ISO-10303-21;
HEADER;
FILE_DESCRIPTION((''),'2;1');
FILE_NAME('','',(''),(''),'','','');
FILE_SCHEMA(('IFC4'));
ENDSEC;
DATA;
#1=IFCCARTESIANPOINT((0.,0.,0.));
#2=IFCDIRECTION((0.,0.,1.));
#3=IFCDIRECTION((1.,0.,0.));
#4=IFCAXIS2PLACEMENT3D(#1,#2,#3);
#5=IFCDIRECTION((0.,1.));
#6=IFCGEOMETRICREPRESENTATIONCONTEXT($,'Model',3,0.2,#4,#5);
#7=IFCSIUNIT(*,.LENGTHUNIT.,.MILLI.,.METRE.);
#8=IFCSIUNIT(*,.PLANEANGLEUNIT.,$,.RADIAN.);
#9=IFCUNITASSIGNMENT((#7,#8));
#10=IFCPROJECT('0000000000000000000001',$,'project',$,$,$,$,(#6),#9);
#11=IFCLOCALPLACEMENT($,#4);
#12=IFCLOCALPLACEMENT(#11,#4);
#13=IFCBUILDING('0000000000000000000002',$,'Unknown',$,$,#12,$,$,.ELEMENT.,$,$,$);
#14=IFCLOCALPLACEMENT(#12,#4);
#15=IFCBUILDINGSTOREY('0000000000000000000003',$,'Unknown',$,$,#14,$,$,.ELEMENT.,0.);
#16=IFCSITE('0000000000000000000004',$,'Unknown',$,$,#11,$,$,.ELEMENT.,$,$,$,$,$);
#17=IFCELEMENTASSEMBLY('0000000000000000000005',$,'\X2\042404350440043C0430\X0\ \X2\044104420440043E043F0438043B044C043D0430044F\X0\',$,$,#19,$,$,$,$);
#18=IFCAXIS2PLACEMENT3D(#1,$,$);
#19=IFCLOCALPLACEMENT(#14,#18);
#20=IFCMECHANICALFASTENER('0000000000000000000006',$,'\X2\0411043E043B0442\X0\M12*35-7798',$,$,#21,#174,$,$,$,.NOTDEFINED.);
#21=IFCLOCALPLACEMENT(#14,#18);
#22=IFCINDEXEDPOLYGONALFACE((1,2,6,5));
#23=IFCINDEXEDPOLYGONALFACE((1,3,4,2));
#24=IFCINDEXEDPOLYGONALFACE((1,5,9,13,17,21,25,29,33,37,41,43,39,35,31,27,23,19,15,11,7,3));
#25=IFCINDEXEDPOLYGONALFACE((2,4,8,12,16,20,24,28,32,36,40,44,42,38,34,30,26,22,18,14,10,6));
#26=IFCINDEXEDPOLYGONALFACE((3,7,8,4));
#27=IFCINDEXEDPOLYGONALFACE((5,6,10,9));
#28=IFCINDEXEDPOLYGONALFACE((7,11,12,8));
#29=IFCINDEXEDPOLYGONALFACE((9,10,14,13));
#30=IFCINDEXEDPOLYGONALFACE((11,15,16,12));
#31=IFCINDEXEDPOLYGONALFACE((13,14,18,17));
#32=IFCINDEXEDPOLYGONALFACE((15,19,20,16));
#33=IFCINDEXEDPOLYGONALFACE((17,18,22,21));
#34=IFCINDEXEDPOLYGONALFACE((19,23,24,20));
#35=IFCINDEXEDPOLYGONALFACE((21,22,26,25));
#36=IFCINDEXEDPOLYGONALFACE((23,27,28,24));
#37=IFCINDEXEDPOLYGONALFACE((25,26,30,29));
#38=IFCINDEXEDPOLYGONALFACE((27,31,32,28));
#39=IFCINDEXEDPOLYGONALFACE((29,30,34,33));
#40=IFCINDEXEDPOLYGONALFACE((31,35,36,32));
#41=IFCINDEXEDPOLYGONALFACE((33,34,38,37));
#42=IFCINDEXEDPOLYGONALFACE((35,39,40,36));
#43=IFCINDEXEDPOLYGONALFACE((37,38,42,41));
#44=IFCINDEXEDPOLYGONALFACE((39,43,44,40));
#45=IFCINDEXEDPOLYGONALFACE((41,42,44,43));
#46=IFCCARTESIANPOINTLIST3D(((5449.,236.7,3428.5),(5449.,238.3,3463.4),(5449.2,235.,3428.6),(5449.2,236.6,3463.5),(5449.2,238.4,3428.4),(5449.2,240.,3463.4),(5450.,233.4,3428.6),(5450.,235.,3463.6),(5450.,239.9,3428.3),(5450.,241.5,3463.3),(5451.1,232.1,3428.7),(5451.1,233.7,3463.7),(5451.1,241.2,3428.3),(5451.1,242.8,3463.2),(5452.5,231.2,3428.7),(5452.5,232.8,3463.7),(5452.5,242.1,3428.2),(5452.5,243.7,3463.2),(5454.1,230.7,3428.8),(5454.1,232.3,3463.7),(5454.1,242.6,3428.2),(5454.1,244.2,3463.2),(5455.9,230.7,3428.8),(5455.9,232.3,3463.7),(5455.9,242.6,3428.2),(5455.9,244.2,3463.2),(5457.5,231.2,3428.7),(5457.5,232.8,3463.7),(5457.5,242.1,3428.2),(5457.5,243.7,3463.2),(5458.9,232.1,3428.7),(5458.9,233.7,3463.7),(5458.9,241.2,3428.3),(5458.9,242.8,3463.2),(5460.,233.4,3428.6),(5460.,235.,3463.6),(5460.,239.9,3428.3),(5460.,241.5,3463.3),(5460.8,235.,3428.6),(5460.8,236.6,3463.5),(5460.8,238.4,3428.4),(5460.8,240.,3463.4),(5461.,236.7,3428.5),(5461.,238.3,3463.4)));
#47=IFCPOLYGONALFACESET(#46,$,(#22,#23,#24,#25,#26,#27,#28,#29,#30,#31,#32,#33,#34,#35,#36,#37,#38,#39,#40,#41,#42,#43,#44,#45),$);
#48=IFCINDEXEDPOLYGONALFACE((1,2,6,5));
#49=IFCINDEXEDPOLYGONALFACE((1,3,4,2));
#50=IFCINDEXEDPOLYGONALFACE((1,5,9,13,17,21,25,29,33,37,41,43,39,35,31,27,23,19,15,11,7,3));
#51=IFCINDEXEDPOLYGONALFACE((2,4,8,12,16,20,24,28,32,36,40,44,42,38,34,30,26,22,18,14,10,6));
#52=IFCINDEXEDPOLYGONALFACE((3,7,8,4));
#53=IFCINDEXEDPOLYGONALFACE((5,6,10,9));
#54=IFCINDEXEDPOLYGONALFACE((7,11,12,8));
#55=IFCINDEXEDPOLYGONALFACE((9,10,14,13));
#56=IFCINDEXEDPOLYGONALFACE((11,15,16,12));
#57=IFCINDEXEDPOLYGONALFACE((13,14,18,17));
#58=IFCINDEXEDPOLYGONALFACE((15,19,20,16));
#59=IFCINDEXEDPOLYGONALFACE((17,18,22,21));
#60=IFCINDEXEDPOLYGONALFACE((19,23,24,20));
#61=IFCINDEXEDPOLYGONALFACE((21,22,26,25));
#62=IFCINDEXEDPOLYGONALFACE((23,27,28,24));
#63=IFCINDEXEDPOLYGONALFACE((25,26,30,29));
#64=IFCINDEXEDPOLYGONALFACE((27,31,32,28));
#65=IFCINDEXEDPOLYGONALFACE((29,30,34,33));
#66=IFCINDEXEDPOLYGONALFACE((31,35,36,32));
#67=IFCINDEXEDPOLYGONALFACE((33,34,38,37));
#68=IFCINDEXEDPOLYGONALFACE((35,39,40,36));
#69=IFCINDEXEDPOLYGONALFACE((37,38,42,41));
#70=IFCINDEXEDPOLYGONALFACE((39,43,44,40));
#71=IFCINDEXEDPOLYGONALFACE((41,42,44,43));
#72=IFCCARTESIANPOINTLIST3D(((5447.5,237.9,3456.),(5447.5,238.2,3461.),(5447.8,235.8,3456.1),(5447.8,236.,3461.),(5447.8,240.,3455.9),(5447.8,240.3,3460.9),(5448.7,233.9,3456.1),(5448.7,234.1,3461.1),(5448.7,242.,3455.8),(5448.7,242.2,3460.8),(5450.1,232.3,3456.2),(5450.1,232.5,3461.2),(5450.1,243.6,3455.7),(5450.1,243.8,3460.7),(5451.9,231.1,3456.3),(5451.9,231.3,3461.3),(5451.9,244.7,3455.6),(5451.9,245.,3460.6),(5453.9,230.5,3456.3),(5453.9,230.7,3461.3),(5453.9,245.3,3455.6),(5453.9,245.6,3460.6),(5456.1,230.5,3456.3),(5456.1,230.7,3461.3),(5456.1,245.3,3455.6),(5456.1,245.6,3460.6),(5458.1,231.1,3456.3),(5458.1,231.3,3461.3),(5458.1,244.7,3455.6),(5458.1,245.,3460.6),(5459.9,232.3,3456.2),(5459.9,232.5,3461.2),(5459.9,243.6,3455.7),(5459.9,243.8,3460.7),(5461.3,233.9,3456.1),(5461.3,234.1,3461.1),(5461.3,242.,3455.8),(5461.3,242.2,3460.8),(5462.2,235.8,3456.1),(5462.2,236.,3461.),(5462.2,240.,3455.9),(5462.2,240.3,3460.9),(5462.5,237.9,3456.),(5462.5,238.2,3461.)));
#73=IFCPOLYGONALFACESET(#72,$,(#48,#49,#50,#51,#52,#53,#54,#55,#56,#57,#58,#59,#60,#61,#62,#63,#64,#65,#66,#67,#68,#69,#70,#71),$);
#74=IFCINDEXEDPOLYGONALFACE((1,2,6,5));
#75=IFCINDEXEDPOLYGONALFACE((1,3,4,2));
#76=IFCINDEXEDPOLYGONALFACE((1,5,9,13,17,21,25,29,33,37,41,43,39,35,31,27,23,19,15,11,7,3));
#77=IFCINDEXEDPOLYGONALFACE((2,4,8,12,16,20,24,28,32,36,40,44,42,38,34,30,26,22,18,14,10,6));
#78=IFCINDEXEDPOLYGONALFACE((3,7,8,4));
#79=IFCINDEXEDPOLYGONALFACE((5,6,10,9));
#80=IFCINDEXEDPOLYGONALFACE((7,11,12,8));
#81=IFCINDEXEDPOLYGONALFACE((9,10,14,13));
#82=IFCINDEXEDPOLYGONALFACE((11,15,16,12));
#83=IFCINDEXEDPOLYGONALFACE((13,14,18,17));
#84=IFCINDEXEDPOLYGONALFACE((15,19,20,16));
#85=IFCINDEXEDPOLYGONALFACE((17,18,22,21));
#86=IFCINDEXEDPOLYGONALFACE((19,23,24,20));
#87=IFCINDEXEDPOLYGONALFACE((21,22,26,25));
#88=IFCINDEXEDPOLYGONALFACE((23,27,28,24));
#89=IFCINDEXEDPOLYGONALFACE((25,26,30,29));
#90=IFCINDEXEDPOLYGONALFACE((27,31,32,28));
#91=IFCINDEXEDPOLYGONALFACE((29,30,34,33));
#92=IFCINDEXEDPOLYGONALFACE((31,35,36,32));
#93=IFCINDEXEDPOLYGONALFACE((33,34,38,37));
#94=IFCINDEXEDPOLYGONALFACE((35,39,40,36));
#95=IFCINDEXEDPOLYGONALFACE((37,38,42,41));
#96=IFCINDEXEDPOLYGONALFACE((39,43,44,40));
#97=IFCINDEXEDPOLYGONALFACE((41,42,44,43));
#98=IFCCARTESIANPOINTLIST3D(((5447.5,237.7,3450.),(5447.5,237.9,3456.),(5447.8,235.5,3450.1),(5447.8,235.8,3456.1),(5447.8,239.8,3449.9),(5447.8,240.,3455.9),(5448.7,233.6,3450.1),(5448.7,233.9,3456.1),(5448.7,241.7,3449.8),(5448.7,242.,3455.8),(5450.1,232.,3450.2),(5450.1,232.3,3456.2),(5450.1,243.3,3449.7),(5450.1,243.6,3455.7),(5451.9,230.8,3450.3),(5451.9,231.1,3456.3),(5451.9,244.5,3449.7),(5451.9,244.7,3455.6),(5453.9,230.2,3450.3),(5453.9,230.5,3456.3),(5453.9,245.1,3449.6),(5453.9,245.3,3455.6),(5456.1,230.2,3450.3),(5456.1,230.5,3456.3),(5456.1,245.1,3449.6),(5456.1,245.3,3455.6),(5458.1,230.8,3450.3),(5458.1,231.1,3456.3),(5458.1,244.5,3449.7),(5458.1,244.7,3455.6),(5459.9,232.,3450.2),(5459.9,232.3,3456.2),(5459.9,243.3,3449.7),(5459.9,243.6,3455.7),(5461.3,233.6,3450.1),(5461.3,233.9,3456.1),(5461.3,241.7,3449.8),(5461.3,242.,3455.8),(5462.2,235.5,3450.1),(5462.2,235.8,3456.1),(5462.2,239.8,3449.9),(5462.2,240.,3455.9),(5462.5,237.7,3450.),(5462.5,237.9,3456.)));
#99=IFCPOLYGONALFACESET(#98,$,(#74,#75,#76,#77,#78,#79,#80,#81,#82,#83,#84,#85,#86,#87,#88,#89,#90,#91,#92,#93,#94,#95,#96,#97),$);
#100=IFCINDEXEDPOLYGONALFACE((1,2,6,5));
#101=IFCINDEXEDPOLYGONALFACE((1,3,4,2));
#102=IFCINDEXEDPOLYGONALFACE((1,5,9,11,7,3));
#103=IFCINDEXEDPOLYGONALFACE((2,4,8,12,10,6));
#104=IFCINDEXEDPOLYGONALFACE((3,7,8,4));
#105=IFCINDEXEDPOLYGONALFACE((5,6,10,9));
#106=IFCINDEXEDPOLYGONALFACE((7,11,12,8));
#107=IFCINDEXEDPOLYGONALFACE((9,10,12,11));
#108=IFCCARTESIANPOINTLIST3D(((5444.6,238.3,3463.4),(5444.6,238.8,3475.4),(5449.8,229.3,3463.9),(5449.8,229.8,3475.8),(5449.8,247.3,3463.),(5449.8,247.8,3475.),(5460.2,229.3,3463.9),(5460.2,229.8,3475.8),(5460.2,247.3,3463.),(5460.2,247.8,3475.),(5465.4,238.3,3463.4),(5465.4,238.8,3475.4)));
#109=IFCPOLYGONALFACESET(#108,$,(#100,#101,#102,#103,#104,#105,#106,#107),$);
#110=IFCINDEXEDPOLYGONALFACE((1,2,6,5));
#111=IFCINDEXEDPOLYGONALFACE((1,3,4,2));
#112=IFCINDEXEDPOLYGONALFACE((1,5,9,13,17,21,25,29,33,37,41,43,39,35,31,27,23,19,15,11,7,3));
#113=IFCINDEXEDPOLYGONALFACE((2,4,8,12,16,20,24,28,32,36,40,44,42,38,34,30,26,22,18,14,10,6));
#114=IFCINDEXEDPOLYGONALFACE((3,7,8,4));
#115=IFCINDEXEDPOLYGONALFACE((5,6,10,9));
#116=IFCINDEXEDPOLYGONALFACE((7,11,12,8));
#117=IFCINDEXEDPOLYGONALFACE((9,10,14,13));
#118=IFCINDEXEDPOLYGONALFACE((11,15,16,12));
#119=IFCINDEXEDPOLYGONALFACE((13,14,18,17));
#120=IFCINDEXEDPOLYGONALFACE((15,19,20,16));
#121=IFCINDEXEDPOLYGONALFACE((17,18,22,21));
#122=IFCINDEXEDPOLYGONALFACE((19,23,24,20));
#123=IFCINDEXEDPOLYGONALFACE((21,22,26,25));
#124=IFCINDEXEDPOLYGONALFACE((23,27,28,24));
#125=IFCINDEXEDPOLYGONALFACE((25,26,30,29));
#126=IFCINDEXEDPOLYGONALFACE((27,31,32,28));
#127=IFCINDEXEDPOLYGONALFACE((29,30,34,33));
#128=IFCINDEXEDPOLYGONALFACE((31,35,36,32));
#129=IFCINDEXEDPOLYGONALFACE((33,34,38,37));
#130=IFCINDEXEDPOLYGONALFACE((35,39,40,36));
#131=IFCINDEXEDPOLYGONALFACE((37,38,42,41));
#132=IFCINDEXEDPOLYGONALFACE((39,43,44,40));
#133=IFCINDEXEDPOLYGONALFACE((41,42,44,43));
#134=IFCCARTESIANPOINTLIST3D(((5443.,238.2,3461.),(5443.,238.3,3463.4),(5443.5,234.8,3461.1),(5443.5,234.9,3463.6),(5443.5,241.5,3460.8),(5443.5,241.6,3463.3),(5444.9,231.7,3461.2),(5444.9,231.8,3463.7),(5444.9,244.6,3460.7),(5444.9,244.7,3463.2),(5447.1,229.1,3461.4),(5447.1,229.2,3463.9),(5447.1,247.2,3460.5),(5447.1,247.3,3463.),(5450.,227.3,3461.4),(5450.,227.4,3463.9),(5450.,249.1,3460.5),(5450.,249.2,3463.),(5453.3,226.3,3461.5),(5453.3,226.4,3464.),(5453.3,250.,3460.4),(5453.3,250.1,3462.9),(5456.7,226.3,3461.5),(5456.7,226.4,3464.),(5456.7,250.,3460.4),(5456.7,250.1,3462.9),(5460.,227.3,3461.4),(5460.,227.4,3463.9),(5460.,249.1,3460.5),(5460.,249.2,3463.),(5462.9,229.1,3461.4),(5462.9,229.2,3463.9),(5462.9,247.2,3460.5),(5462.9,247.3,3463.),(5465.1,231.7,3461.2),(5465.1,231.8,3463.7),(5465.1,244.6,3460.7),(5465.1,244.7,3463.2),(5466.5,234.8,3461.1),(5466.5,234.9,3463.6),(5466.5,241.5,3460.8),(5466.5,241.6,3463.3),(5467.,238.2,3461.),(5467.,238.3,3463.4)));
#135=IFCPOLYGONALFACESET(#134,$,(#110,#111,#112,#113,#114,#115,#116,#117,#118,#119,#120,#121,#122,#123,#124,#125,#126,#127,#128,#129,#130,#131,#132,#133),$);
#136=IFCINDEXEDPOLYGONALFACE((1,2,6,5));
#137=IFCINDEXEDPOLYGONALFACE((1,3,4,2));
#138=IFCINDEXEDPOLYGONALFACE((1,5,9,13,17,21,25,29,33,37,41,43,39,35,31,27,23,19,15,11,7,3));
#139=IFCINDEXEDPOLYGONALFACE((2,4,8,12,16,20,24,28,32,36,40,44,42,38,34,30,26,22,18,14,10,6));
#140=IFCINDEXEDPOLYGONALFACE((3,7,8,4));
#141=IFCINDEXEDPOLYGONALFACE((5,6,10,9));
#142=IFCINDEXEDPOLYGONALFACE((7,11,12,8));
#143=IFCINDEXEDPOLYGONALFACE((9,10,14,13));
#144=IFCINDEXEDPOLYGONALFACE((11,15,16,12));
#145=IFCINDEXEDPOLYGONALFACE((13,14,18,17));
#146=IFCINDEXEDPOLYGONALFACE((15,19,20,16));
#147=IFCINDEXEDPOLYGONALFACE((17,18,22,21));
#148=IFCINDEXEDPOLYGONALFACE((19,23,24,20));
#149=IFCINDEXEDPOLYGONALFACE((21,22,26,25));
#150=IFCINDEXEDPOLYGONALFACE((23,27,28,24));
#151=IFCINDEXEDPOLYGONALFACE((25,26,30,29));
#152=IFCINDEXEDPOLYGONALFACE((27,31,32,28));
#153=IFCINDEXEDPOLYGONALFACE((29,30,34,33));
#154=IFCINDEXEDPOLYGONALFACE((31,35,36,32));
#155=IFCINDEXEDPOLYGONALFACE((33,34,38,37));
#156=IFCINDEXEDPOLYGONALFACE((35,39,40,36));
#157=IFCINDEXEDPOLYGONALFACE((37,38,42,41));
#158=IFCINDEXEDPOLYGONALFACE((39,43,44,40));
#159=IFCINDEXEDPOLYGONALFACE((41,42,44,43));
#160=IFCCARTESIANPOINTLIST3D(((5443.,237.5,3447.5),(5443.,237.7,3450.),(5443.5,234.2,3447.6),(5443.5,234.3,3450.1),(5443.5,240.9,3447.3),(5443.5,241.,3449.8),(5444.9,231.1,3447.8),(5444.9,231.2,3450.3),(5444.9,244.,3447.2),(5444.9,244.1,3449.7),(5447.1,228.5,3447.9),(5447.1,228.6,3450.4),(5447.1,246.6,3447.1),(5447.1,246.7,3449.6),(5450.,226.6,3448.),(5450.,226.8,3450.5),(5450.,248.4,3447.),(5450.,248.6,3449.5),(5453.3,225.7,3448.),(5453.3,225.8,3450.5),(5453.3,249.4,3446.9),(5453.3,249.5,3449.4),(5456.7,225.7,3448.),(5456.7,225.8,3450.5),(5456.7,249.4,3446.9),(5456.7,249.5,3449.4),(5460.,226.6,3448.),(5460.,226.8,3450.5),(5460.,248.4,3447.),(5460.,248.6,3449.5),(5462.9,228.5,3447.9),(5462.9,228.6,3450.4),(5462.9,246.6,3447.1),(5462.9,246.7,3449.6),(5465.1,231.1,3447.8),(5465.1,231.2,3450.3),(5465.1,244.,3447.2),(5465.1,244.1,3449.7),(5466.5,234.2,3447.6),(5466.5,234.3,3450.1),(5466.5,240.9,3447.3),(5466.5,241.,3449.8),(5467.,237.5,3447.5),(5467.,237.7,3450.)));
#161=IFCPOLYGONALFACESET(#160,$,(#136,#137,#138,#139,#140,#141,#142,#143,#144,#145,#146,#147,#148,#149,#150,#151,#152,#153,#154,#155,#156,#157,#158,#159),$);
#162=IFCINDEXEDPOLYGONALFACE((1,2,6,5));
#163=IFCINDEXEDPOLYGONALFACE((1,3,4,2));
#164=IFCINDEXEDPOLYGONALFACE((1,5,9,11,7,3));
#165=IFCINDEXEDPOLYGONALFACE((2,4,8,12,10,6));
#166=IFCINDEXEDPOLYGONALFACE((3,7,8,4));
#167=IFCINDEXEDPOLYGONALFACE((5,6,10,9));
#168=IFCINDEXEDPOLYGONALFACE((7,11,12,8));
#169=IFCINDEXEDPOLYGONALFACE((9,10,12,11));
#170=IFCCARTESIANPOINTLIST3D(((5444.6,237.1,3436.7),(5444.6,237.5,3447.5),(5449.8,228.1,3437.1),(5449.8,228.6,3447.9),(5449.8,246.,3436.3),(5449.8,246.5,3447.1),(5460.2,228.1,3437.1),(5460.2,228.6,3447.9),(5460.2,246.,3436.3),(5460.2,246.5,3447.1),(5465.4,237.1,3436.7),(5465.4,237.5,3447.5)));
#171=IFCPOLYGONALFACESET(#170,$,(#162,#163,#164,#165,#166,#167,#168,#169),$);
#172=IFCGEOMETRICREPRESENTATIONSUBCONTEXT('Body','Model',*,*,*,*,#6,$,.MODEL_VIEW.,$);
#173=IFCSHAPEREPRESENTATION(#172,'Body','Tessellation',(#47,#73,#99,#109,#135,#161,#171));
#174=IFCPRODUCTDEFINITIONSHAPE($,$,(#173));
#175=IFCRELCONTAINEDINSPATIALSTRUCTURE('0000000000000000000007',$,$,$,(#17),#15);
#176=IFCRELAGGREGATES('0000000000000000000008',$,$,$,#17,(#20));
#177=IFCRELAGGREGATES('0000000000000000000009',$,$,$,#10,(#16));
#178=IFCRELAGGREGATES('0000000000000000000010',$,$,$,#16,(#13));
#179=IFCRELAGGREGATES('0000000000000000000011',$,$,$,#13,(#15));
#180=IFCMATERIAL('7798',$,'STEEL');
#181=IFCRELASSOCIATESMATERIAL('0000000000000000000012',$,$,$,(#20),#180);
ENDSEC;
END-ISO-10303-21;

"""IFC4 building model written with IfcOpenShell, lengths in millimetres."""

from ifc_helpers import new_model, si_unit, direction, frame, origin_with_axes, place, context, subcontext, project, spatial, line, arc, indexed_curve, outline, extrude, source, transform, mapped, material, element, aggregate, save


model = new_model("IFC4")

# Units and contexts
model_context = context("Model", 3, precision=0.2, world=origin_with_axes(), true_north=direction((0.0, 1.0)))
body_context = subcontext(model_context, "Body", "Model", "MODEL_VIEW")
ifc_project = project(units=[si_unit("LENGTHUNIT", "METRE", prefix="MILLI"), si_unit("PLANEANGLEUNIT", "RADIAN")], contexts=[model_context])

# Site, building, storey
site_placement = place(None, origin_with_axes())
site = spatial("IfcSite", under=ifc_project, at=site_placement, Name="Unknown", CompositionType="ELEMENT")
building_placement = place(site_placement, origin_with_axes())
building = spatial("IfcBuilding", under=site, at=building_placement, Name="Unknown", CompositionType="ELEMENT")
storey_placement = place(building_placement, origin_with_axes())
storey = spatial("IfcBuildingStorey", under=building, at=storey_placement, Name="Unknown", CompositionType="ELEMENT", Elevation=0.0)

# Element assembly
assembly_1_placement = place(storey_placement, frame((5400.0, 88.6, 3426.7), z_axis=(1.0, 0.0, 0.0), x_axis=(0.0, 0.998969, -0.045408)))
assembly_1 = element("IfcElementAssembly", 1, at=assembly_1_placement, inside=storey, Name="Ферма стропильная")

# Mechanical fastener
ifc_material_1 = material(Name="7798", Category="STEEL")
shared_shape_1 = source(origin_with_axes(), body_context, "Body", "SweptSolid", [
    extrude(outline(indexed_curve([(6.0, 0.0), (0.0, 6.0), (-6.0, 0.0), (0.0, -6.0)], segments=[arc(1, 2, 3), arc(3, 4, 1)])), frame((0.0, 0.0, 7.5), z_axis=(0.0, 0.0, -1.0), x_axis=(0.0, 1.0, 0.0)), (0.0, 0.0, 1.0), 35.0),
    extrude(outline(indexed_curve([(7.5, 0.0), (0.0, 7.5), (-7.5, 0.0), (0.0, -7.5)], segments=[arc(1, 2, 3), arc(3, 4, 1)])), frame((0.0, 0.0, 5.0), z_axis=(0.0, 0.0, -1.0), x_axis=(0.0, 1.0, 0.0)), (0.0, 0.0, 1.0), 5.0),
    extrude(outline(indexed_curve([(7.5, 0.0), (0.0, 7.5), (-7.5, 0.0), (0.0, -7.5)], segments=[arc(1, 2, 3), arc(3, 4, 1)])), frame((0.0, 0.0, 0.0), z_axis=(0.0, 0.0, -1.0), x_axis=(0.0, 1.0, 0.0)), (0.0, 0.0, 1.0), 6.0),
    extrude(outline(indexed_curve([(10.4, 0.0), (5.2, 9.0), (-5.2, 9.0), (-10.4, 0.0), (-5.2, -9.0), (5.2, -9.0)], segments=[line(1, 2, 3, 4, 5, 6, 1)])), frame((0.0, 0.0, 19.5), z_axis=(0.0, 0.0, -1.0), x_axis=(0.0, 1.0, 0.0)), (0.0, 0.0, 1.0), 12.0),
    extrude(outline(indexed_curve([(12.0, 0.0), (0.0, 12.0), (-12.0, 0.0), (0.0, -12.0)], segments=[arc(1, 2, 3), arc(3, 4, 1)])), frame((0.0, 0.0, 7.5), z_axis=(0.0, 0.0, -1.0), x_axis=(0.0, 1.0, 0.0)), (0.0, 0.0, 1.0), 2.5),
    extrude(outline(indexed_curve([(12.0, 0.0), (0.0, 12.0), (-12.0, 0.0), (0.0, -12.0)], segments=[arc(1, 2, 3), arc(3, 4, 1)])), frame((0.0, 0.0, -6.0), z_axis=(0.0, 0.0, -1.0), x_axis=(0.0, 1.0, 0.0)), (0.0, 0.0, 1.0), 2.5),
    extrude(outline(indexed_curve([(10.4, 0.0), (5.2, 9.0), (-5.2, 9.0), (-10.4, 0.0), (-5.2, -9.0), (5.2, -9.0)], segments=[line(1, 2, 3, 4, 5, 6, 1)])), frame((0.0, 0.0, -8.5), z_axis=(0.0, 0.0, -1.0), x_axis=(0.0, 1.0, 0.0)), (0.0, 0.0, 1.0), 10.8),
])
mechanical_fastener_1_placement = place(assembly_1_placement, frame((147.8, 36.0, 55.0), z_axis=(0.0, 1.0, 0.0), x_axis=(-1.0, 0.0, 0.0)))
mechanical_fastener_1 = element("IfcMechanicalFastener", 2, at=mechanical_fastener_1_placement, material=ifc_material_1, Name="БолтM12*35-7798", PredefinedType="NOTDEFINED", context=body_context, shape_type="MappedRepresentation", body=[
    mapped(shared_shape_1, transform((0.0, 0.0, 0.0))),
])
aggregate(assembly_1, [mechanical_fastener_1])

save(model, "model.ifc")
